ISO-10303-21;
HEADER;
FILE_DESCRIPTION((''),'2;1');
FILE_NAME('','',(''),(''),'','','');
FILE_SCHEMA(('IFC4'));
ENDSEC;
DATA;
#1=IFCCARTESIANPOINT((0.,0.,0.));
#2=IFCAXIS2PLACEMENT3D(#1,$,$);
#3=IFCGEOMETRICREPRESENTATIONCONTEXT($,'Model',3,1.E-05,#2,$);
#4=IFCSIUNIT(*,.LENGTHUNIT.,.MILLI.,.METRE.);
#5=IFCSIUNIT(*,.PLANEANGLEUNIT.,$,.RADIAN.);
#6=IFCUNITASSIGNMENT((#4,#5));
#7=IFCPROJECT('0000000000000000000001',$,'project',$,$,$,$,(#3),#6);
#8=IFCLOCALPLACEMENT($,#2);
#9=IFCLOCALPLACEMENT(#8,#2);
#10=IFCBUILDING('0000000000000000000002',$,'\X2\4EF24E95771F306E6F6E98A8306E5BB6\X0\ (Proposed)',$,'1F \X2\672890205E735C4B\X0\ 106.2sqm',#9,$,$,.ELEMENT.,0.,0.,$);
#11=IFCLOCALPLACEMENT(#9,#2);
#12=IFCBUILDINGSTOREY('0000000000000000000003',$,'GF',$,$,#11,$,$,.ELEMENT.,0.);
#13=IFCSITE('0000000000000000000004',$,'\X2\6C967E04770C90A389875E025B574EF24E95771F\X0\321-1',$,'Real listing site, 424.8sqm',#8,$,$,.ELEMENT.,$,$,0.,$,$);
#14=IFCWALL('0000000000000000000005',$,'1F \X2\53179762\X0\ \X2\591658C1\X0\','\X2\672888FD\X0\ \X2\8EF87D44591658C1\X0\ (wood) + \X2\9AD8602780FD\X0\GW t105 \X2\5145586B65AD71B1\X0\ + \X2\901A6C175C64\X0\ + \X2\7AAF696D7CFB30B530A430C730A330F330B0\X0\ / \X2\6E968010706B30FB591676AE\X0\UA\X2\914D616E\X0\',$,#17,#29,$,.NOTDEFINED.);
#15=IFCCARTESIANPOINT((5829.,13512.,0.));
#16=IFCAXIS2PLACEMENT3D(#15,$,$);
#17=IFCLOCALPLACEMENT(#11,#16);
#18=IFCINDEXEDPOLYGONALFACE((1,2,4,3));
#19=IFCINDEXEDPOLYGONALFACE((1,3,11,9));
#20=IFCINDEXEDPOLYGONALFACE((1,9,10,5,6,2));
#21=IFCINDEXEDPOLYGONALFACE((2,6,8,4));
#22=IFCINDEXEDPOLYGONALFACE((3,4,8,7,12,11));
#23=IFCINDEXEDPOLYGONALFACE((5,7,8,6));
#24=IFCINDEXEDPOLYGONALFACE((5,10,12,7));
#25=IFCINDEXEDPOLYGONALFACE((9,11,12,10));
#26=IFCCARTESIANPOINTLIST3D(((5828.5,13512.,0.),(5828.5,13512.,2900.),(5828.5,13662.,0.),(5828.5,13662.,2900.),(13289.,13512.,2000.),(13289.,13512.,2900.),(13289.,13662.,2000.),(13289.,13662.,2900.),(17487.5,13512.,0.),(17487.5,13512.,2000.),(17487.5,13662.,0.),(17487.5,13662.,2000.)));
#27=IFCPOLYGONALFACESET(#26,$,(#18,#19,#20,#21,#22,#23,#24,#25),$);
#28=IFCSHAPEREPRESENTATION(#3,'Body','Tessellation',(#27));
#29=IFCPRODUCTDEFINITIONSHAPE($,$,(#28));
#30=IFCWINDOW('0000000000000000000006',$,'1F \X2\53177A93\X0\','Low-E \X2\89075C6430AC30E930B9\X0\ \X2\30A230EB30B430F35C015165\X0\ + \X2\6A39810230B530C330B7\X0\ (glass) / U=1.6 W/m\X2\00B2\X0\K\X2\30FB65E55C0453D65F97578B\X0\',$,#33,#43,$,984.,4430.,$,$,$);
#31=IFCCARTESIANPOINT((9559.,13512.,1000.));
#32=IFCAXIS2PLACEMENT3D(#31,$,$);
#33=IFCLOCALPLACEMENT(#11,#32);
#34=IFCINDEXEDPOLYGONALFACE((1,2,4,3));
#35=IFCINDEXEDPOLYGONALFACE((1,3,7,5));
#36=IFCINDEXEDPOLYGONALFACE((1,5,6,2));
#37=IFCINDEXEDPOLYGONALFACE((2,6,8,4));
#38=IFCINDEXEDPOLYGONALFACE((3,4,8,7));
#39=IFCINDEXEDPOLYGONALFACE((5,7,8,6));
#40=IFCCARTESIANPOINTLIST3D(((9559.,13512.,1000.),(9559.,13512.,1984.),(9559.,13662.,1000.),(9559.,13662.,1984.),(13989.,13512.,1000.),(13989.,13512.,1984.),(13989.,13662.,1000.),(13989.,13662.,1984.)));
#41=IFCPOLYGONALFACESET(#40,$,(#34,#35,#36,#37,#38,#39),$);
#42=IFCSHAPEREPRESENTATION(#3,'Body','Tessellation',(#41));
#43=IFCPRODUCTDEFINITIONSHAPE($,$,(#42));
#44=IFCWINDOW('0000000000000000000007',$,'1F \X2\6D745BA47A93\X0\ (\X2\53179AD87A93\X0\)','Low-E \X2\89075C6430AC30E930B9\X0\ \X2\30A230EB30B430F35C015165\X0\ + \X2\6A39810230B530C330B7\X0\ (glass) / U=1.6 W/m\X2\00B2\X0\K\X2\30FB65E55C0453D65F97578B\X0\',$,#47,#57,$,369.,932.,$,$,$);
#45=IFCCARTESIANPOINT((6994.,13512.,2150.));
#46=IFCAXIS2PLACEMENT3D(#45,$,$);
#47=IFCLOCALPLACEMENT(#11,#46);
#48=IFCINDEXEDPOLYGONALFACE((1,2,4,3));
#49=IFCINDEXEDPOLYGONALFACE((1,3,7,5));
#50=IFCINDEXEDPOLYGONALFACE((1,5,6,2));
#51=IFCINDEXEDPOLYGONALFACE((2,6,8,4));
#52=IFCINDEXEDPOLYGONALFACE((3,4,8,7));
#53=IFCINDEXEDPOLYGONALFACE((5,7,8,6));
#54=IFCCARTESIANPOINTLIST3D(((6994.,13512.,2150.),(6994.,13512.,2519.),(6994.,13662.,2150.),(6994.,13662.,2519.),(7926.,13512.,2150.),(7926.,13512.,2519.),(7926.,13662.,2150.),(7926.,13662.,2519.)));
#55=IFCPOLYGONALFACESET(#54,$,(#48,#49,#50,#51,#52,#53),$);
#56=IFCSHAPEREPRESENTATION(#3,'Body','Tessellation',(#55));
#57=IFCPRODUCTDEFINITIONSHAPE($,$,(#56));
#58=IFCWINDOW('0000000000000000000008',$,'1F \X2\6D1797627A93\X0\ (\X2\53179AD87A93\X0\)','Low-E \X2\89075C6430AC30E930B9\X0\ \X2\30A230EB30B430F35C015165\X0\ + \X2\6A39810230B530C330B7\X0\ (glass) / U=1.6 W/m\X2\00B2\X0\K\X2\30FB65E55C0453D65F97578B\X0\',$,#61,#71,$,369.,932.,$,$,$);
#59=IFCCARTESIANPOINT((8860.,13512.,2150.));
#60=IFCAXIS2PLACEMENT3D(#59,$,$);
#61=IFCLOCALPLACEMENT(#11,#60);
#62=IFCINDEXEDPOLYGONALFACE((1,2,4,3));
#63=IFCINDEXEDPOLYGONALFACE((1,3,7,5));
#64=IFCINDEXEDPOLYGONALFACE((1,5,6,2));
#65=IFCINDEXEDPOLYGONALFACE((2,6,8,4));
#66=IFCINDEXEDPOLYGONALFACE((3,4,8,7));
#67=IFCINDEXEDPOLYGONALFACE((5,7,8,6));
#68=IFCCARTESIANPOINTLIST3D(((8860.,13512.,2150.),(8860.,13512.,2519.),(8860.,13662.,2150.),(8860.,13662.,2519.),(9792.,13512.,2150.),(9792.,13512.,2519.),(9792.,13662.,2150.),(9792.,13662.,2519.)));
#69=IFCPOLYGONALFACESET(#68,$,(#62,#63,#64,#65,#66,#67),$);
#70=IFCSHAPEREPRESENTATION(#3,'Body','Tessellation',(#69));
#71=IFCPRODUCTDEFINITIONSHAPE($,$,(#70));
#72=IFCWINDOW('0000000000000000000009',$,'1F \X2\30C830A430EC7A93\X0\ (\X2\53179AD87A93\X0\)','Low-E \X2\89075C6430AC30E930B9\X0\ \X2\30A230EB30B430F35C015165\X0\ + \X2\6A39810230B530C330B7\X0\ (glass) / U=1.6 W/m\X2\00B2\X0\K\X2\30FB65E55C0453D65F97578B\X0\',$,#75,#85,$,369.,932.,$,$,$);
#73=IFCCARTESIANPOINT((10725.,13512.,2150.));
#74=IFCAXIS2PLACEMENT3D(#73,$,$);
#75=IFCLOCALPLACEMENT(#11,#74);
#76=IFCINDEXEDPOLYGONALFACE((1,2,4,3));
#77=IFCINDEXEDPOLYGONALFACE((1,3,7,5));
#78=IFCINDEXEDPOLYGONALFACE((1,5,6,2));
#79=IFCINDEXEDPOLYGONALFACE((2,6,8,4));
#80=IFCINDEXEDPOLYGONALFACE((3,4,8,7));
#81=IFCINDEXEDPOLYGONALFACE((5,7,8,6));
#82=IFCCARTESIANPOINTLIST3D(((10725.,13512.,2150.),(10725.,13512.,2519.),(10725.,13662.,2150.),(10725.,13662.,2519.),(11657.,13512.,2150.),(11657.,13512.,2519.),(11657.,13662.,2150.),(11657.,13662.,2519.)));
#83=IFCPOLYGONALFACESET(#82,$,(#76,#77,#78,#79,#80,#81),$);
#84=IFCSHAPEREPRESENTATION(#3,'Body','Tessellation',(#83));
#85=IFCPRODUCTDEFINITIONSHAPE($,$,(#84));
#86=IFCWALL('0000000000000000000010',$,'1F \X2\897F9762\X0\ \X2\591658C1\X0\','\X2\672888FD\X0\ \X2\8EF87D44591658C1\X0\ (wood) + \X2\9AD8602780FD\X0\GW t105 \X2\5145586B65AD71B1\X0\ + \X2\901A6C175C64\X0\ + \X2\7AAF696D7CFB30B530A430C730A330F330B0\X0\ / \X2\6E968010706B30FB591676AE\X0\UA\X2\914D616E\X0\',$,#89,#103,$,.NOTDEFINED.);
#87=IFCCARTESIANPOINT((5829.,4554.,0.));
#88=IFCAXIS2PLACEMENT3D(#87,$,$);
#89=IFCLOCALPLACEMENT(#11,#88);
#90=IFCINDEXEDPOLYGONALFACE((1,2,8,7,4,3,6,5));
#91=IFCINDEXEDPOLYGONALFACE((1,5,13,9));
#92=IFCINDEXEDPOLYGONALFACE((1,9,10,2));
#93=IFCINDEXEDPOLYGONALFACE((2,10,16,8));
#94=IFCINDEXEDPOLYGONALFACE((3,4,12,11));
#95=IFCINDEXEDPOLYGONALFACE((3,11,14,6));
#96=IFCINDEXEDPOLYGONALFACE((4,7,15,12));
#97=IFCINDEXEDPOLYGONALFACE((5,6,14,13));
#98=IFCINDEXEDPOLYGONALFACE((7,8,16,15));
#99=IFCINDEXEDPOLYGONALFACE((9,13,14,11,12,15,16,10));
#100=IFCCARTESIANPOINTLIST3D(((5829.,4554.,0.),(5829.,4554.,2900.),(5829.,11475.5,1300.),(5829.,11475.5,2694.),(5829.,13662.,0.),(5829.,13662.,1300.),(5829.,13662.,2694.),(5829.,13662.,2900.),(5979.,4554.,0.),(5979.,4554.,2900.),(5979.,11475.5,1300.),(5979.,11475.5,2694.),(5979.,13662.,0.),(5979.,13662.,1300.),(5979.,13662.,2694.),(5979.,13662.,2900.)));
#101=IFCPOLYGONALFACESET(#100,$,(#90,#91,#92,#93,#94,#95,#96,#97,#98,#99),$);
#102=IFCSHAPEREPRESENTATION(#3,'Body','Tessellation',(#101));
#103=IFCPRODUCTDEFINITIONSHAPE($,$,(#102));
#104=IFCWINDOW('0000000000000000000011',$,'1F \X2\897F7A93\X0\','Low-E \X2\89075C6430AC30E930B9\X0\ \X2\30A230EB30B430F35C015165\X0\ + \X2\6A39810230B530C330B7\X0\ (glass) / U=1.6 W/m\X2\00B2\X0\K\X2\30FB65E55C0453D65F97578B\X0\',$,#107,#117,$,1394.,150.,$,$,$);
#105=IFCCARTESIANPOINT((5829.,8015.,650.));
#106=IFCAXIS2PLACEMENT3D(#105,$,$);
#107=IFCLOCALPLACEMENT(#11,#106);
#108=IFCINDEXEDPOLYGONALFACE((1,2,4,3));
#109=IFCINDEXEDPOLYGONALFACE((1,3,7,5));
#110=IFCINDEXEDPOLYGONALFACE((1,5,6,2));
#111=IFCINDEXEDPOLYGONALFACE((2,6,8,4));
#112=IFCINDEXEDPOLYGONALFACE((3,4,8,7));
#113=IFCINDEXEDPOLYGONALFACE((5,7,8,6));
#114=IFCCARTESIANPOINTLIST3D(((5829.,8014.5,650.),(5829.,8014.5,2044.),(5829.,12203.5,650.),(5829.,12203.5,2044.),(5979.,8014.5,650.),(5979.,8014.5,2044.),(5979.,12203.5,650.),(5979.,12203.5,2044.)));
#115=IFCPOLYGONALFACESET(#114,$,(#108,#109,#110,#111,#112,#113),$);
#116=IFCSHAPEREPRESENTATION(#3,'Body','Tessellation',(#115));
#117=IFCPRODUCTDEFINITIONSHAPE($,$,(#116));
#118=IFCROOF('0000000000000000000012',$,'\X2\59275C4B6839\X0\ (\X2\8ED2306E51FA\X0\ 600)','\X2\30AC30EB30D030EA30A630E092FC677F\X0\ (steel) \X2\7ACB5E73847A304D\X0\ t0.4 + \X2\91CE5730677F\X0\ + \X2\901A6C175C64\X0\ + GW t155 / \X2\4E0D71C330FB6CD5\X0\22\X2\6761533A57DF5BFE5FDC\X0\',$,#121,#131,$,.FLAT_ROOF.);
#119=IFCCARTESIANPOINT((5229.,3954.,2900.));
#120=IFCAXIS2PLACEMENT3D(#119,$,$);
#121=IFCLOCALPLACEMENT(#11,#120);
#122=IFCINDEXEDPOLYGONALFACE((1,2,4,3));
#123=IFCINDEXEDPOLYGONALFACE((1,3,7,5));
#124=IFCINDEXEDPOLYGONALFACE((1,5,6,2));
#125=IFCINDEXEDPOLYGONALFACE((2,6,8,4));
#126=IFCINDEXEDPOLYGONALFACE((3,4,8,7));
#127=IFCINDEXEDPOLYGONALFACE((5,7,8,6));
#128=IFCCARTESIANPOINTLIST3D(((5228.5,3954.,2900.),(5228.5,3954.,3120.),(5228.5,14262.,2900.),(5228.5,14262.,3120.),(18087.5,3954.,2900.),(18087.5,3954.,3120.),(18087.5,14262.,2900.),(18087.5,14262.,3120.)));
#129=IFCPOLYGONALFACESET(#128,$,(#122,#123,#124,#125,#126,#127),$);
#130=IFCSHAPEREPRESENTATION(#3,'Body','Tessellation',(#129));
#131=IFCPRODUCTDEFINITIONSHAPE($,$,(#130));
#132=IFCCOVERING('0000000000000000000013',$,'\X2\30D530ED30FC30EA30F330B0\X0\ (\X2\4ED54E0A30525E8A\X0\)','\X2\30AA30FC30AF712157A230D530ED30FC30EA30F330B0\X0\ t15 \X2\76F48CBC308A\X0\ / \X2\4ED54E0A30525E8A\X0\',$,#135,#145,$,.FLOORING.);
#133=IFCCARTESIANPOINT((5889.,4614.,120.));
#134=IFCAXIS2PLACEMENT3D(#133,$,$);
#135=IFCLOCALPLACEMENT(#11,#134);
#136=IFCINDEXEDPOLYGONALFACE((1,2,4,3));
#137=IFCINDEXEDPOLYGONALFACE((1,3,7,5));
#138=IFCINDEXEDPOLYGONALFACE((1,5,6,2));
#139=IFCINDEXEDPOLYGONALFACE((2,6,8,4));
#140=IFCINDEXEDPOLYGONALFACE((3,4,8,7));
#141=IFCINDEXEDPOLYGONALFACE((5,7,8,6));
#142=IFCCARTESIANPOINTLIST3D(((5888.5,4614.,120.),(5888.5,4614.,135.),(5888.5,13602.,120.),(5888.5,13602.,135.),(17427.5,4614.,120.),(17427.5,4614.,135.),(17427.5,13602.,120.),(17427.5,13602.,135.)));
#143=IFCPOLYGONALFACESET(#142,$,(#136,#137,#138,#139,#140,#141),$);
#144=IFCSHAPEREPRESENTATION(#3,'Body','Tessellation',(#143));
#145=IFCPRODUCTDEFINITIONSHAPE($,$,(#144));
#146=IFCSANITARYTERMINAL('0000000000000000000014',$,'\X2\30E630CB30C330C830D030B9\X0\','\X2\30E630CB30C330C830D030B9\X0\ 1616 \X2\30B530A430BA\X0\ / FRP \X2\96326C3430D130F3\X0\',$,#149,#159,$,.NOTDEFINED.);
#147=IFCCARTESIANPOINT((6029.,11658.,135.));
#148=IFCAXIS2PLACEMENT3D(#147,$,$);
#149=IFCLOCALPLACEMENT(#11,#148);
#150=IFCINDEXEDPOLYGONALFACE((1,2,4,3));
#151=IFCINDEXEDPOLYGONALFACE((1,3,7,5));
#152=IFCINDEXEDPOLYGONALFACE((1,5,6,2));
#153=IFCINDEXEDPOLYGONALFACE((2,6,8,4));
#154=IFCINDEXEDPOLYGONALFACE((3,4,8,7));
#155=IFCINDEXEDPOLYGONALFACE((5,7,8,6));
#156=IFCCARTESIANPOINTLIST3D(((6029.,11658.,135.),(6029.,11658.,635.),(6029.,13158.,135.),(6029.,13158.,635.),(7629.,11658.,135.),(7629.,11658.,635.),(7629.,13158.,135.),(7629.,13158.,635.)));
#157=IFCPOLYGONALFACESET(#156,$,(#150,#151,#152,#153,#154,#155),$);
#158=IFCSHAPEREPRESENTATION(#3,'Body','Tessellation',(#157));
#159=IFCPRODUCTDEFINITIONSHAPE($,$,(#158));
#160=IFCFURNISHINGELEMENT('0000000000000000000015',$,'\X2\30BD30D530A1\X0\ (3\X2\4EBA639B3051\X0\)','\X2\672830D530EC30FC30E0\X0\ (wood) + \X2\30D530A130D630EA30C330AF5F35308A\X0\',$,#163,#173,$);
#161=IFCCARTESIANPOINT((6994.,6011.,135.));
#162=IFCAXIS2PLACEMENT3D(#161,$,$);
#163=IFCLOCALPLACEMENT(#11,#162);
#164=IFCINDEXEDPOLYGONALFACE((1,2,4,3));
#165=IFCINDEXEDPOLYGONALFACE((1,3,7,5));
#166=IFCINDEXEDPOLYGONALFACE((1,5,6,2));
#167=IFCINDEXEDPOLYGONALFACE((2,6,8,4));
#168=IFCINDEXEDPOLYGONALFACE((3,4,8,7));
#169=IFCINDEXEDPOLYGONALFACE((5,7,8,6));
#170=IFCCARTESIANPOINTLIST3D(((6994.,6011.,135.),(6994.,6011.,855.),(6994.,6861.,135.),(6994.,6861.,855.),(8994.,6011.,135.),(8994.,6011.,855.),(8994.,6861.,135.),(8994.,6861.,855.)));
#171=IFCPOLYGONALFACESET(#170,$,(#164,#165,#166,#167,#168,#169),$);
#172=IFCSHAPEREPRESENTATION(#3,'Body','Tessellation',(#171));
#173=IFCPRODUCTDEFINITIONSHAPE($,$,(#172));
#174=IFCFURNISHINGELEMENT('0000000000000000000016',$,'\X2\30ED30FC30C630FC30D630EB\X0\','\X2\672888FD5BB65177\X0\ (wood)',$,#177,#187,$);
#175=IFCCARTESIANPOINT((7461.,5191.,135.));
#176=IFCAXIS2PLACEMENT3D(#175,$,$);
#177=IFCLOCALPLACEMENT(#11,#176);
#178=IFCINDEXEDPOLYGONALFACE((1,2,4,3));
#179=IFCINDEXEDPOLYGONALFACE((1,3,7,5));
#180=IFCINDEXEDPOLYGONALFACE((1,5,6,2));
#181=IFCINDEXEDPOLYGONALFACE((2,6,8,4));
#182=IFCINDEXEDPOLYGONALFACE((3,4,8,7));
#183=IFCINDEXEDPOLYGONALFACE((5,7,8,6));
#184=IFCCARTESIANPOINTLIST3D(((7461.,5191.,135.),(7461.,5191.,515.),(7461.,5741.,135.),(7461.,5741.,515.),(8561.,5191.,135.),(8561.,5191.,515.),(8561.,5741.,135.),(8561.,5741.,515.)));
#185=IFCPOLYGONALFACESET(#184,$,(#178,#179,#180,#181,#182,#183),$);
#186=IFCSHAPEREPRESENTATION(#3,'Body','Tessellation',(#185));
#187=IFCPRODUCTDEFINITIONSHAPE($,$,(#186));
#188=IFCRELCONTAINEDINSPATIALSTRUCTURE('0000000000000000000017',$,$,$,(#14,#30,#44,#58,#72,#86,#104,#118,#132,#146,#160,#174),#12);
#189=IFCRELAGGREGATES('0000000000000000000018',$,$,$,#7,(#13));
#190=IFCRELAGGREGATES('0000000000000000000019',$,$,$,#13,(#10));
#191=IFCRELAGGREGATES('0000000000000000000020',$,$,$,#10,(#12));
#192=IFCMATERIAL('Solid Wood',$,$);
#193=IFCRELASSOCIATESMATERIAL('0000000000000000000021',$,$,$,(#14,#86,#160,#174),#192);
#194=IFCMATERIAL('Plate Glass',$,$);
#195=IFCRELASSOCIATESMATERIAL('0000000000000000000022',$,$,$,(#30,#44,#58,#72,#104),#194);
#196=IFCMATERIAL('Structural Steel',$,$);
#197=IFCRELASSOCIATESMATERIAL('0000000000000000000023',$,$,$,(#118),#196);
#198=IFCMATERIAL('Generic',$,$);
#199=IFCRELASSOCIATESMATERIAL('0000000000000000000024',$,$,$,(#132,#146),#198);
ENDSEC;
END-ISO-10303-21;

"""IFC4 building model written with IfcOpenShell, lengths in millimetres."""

from ifc_helpers import new_model, si_unit, frame, frame_2d, origin, place, context, project, spatial, rectangle, extrude, material, element, fill, save


model = new_model("IFC4")

# Units and contexts
model_context = context("Model", 3, precision=1e-05, world=origin())
ifc_project = project(units=[si_unit("LENGTHUNIT", "METRE", prefix="MILLI"), si_unit("PLANEANGLEUNIT", "RADIAN")], contexts=[model_context])

# Site, building, storey
site_placement = place(None, origin())
site = spatial("IfcSite", under=ifc_project, at=site_placement, Name="沖縄県那覇市字仲井真321-1", ObjectType="Real listing site, 424.8sqm", CompositionType="ELEMENT", RefElevation=0.0)
building_placement = place(site_placement, origin())
building = spatial("IfcBuilding", under=site, at=building_placement, Name="仲井真の潮風の家 (Proposed)", ObjectType="1F 木造平屋 106.2sqm", CompositionType="ELEMENT", ElevationOfRefHeight=0.0, ElevationOfTerrain=0.0)
storey_placement = place(building_placement, origin())
storey = spatial("IfcBuildingStorey", under=building, at=storey_placement, Name="GF", CompositionType="ELEMENT", Elevation=0.0)

# Shared definitions
ifc_material_1 = material(Name="Solid Wood")

# Shared definitions
ifc_material_2 = material(Name="Plate Glass")

# Wall, openings, windows
wall_1_placement = place(storey_placement, frame((5829.0, 13512.0, 0.0)))
wall_1 = element("IfcWall", 1, at=wall_1_placement, inside=storey, material=ifc_material_1, Name="1F 北面 外壁", Description="木製 軸組外壁 (wood) + 高性能GW t105 充填断熱 + 通気層 + 窯業系サイディング / 準耐火・外皮UA配慮", PredefinedType="NOTDEFINED", context=model_context, shape_type="SweptSolid", body=[
    extrude(rectangle(XDim=11659.0, YDim=150.0, at=frame_2d((5829.0, 75.0))), frame((5829.0, 13512.0, 0.0)), (0.0, 0.0, 1.0), 2900.0),
])
opening_1_placement = place(storey_placement, frame((9559.0, 13512.0, 1000.0)))
opening_1 = element("IfcOpeningElement", 2, at=opening_1_placement, cuts=wall_1, PredefinedType="NOTDEFINED", context=model_context, shape_type="SweptSolid", body=[
    extrude(rectangle(XDim=4430.0, YDim=150.0, at=frame_2d((2215.0, 75.0))), frame((9559.0, 13512.0, 1000.0)), (0.0, 0.0, 1.0), 984.0),
])
opening_2_placement = place(storey_placement, frame((6994.0, 13512.0, 2150.0)))
opening_2 = element("IfcOpeningElement", 3, at=opening_2_placement, cuts=wall_1, PredefinedType="NOTDEFINED", context=model_context, shape_type="SweptSolid", body=[
    extrude(rectangle(XDim=932.0, YDim=150.0, at=frame_2d((466.0, 75.0))), frame((6994.0, 13512.0, 2150.0)), (0.0, 0.0, 1.0), 369.0),
])
opening_3_placement = place(storey_placement, frame((8860.0, 13512.0, 2150.0)))
opening_3 = element("IfcOpeningElement", 4, at=opening_3_placement, cuts=wall_1, PredefinedType="NOTDEFINED", context=model_context, shape_type="SweptSolid", body=[
    extrude(rectangle(XDim=932.0, YDim=150.0, at=frame_2d((466.0, 75.0))), frame((8860.0, 13512.0, 2150.0)), (0.0, 0.0, 1.0), 369.0),
])
opening_4_placement = place(storey_placement, frame((10725.0, 13512.0, 2150.0)))
opening_4 = element("IfcOpeningElement", 5, at=opening_4_placement, cuts=wall_1, PredefinedType="NOTDEFINED", context=model_context, shape_type="SweptSolid", body=[
    extrude(rectangle(XDim=932.0, YDim=150.0, at=frame_2d((466.0, 75.0))), frame((10725.0, 13512.0, 2150.0)), (0.0, 0.0, 1.0), 369.0),
])
window_1_placement = place(storey_placement, frame((9559.0, 13512.0, 1000.0)))
window_1 = element("IfcWindow", 6, at=window_1_placement, inside=storey, material=ifc_material_2, Name="1F 北窓", Description="Low-E 複層ガラス アルゴン封入 + 樹脂サッシ (glass) / U=1.6 W/m²K・日射取得型", OverallHeight=984.0, OverallWidth=4430.0, context=model_context, shape_type="SweptSolid", body=[
    extrude(rectangle(XDim=4430.0, YDim=150.0, at=frame_2d((2215.0, 75.0))), frame((9559.0, 13512.0, 1000.0)), (0.0, 0.0, 1.0), 984.0),
])
fill(opening_1, window_1)
window_2_placement = place(storey_placement, frame((6994.0, 13512.0, 2150.0)))
window_2 = element("IfcWindow", 7, at=window_2_placement, inside=storey, material=ifc_material_2, Name="1F 浴室窓 (北高窓)", Description="Low-E 複層ガラス アルゴン封入 + 樹脂サッシ (glass) / U=1.6 W/m²K・日射取得型", OverallHeight=369.0, OverallWidth=932.0, context=model_context, shape_type="SweptSolid", body=[
    extrude(rectangle(XDim=932.0, YDim=150.0, at=frame_2d((466.0, 75.0))), frame((6994.0, 13512.0, 2150.0)), (0.0, 0.0, 1.0), 369.0),
])
fill(opening_2, window_2)
window_3_placement = place(storey_placement, frame((8860.0, 13512.0, 2150.0)))
window_3 = element("IfcWindow", 8, at=window_3_placement, inside=storey, material=ifc_material_2, Name="1F 洗面窓 (北高窓)", Description="Low-E 複層ガラス アルゴン封入 + 樹脂サッシ (glass) / U=1.6 W/m²K・日射取得型", OverallHeight=369.0, OverallWidth=932.0, context=model_context, shape_type="SweptSolid", body=[
    extrude(rectangle(XDim=932.0, YDim=150.0, at=frame_2d((466.0, 75.0))), frame((8860.0, 13512.0, 2150.0)), (0.0, 0.0, 1.0), 369.0),
])
fill(opening_3, window_3)
window_4_placement = place(storey_placement, frame((10725.0, 13512.0, 2150.0)))
window_4 = element("IfcWindow", 9, at=window_4_placement, inside=storey, material=ifc_material_2, Name="1F トイレ窓 (北高窓)", Description="Low-E 複層ガラス アルゴン封入 + 樹脂サッシ (glass) / U=1.6 W/m²K・日射取得型", OverallHeight=369.0, OverallWidth=932.0, context=model_context, shape_type="SweptSolid", body=[
    extrude(rectangle(XDim=932.0, YDim=150.0, at=frame_2d((466.0, 75.0))), frame((10725.0, 13512.0, 2150.0)), (0.0, 0.0, 1.0), 369.0),
])
fill(opening_4, window_4)

# Wall, opening, window
wall_2_placement = place(storey_placement, frame((5829.0, 4554.0, 0.0)))
wall_2 = element("IfcWall", 10, at=wall_2_placement, inside=storey, material=ifc_material_1, Name="1F 西面 外壁", Description="木製 軸組外壁 (wood) + 高性能GW t105 充填断熱 + 通気層 + 窯業系サイディング / 準耐火・外皮UA配慮", PredefinedType="NOTDEFINED", context=model_context, shape_type="SweptSolid", body=[
    extrude(rectangle(XDim=150.0, YDim=9108.0, at=frame_2d((75.0, 4554.0))), frame((5829.0, 4554.0, 0.0)), (0.0, 0.0, 1.0), 2900.0),
])
opening_5_placement = place(storey_placement, frame((5829.0, 8015.0, 650.0)))
opening_5 = element("IfcOpeningElement", 11, at=opening_5_placement, cuts=wall_2, PredefinedType="NOTDEFINED", context=model_context, shape_type="SweptSolid", body=[
    extrude(rectangle(XDim=150.0, YDim=4189.0, at=frame_2d((75.0, 2094.0))), frame((5829.0, 8015.0, 650.0)), (0.0, 0.0, 1.0), 1394.0),
])
window_5_placement = place(storey_placement, frame((5829.0, 8015.0, 650.0)))
window_5 = element("IfcWindow", 12, at=window_5_placement, inside=storey, material=ifc_material_2, Name="1F 西窓", Description="Low-E 複層ガラス アルゴン封入 + 樹脂サッシ (glass) / U=1.6 W/m²K・日射取得型", OverallHeight=1394.0, OverallWidth=150.0, context=model_context, shape_type="SweptSolid", body=[
    extrude(rectangle(XDim=150.0, YDim=4189.0, at=frame_2d((75.0, 2094.0))), frame((5829.0, 8015.0, 650.0)), (0.0, 0.0, 1.0), 1394.0),
])
fill(opening_5, window_5)

# Roof
ifc_material_3 = material(Name="Structural Steel")
roof_placement = place(storey_placement, frame((5229.0, 3954.0, 2900.0)))
element("IfcRoof", 13, at=roof_placement, inside=storey, material=ifc_material_3, Name="大屋根 (軒の出 600)", Description="ガルバリウム鋼板 (steel) 立平葺き t0.4 + 野地板 + 通気層 + GW t155 / 不燃・法22条区域対応", PredefinedType="FLAT_ROOF", context=model_context, shape_type="SweptSolid", body=[
    extrude(rectangle(XDim=12859.0, YDim=10308.0, at=frame_2d((6429.0, 5154.0))), frame((5229.0, 3954.0, 2900.0)), (0.0, 0.0, 1.0), 220.0),
])

# Covering
ifc_material_4 = material(Name="Generic")
covering_placement = place(storey_placement, frame((5889.0, 4614.0, 120.0)))
element("IfcCovering", 14, at=covering_placement, inside=storey, material=ifc_material_4, Name="フローリング (仕上げ床)", Description="オーク無垢フローリング t15 直貼り / 仕上げ床", PredefinedType="FLOORING", context=model_context, shape_type="SweptSolid", body=[
    extrude(rectangle(XDim=11539.0, YDim=8988.0, at=frame_2d((5769.0, 4494.0))), frame((5889.0, 4614.0, 120.0)), (0.0, 0.0, 1.0), 15.0),
])

# Sanitary terminal
sanitary_terminal_placement = place(storey_placement, frame((6029.0, 11658.0, 135.0)))
element("IfcSanitaryTerminal", 15, at=sanitary_terminal_placement, inside=storey, material=ifc_material_4, Name="ユニットバス", Description="ユニットバス 1616 サイズ / FRP 防水パン", PredefinedType="NOTDEFINED", context=model_context, shape_type="SweptSolid", body=[
    extrude(rectangle(XDim=1600.0, YDim=1500.0, at=frame_2d((800.0, 750.0))), frame((6029.0, 11658.0, 135.0)), (0.0, 0.0, 1.0), 500.0),
])

# Furnishing elements
furnishing_1_placement = place(storey_placement, frame((6994.0, 6011.0, 135.0)))
element("IfcFurnishingElement", 16, at=furnishing_1_placement, inside=storey, material=ifc_material_1, Name="ソファ (3人掛け)", Description="木フレーム (wood) + ファブリック張り", context=model_context, shape_type="SweptSolid", body=[
    extrude(rectangle(XDim=2000.0, YDim=850.0, at=frame_2d((1000.0, 425.0))), frame((6994.0, 6011.0, 135.0)), (0.0, 0.0, 1.0), 720.0),
])
furnishing_2_placement = place(storey_placement, frame((7461.0, 5191.0, 135.0)))
element("IfcFurnishingElement", 17, at=furnishing_2_placement, inside=storey, material=ifc_material_1, Name="ローテーブル", Description="木製家具 (wood)", context=model_context, shape_type="SweptSolid", body=[
    extrude(rectangle(XDim=1100.0, YDim=550.0, at=frame_2d((550.0, 275.0))), frame((7461.0, 5191.0, 135.0)), (0.0, 0.0, 1.0), 380.0),
])

save(model, "model.ifc")
